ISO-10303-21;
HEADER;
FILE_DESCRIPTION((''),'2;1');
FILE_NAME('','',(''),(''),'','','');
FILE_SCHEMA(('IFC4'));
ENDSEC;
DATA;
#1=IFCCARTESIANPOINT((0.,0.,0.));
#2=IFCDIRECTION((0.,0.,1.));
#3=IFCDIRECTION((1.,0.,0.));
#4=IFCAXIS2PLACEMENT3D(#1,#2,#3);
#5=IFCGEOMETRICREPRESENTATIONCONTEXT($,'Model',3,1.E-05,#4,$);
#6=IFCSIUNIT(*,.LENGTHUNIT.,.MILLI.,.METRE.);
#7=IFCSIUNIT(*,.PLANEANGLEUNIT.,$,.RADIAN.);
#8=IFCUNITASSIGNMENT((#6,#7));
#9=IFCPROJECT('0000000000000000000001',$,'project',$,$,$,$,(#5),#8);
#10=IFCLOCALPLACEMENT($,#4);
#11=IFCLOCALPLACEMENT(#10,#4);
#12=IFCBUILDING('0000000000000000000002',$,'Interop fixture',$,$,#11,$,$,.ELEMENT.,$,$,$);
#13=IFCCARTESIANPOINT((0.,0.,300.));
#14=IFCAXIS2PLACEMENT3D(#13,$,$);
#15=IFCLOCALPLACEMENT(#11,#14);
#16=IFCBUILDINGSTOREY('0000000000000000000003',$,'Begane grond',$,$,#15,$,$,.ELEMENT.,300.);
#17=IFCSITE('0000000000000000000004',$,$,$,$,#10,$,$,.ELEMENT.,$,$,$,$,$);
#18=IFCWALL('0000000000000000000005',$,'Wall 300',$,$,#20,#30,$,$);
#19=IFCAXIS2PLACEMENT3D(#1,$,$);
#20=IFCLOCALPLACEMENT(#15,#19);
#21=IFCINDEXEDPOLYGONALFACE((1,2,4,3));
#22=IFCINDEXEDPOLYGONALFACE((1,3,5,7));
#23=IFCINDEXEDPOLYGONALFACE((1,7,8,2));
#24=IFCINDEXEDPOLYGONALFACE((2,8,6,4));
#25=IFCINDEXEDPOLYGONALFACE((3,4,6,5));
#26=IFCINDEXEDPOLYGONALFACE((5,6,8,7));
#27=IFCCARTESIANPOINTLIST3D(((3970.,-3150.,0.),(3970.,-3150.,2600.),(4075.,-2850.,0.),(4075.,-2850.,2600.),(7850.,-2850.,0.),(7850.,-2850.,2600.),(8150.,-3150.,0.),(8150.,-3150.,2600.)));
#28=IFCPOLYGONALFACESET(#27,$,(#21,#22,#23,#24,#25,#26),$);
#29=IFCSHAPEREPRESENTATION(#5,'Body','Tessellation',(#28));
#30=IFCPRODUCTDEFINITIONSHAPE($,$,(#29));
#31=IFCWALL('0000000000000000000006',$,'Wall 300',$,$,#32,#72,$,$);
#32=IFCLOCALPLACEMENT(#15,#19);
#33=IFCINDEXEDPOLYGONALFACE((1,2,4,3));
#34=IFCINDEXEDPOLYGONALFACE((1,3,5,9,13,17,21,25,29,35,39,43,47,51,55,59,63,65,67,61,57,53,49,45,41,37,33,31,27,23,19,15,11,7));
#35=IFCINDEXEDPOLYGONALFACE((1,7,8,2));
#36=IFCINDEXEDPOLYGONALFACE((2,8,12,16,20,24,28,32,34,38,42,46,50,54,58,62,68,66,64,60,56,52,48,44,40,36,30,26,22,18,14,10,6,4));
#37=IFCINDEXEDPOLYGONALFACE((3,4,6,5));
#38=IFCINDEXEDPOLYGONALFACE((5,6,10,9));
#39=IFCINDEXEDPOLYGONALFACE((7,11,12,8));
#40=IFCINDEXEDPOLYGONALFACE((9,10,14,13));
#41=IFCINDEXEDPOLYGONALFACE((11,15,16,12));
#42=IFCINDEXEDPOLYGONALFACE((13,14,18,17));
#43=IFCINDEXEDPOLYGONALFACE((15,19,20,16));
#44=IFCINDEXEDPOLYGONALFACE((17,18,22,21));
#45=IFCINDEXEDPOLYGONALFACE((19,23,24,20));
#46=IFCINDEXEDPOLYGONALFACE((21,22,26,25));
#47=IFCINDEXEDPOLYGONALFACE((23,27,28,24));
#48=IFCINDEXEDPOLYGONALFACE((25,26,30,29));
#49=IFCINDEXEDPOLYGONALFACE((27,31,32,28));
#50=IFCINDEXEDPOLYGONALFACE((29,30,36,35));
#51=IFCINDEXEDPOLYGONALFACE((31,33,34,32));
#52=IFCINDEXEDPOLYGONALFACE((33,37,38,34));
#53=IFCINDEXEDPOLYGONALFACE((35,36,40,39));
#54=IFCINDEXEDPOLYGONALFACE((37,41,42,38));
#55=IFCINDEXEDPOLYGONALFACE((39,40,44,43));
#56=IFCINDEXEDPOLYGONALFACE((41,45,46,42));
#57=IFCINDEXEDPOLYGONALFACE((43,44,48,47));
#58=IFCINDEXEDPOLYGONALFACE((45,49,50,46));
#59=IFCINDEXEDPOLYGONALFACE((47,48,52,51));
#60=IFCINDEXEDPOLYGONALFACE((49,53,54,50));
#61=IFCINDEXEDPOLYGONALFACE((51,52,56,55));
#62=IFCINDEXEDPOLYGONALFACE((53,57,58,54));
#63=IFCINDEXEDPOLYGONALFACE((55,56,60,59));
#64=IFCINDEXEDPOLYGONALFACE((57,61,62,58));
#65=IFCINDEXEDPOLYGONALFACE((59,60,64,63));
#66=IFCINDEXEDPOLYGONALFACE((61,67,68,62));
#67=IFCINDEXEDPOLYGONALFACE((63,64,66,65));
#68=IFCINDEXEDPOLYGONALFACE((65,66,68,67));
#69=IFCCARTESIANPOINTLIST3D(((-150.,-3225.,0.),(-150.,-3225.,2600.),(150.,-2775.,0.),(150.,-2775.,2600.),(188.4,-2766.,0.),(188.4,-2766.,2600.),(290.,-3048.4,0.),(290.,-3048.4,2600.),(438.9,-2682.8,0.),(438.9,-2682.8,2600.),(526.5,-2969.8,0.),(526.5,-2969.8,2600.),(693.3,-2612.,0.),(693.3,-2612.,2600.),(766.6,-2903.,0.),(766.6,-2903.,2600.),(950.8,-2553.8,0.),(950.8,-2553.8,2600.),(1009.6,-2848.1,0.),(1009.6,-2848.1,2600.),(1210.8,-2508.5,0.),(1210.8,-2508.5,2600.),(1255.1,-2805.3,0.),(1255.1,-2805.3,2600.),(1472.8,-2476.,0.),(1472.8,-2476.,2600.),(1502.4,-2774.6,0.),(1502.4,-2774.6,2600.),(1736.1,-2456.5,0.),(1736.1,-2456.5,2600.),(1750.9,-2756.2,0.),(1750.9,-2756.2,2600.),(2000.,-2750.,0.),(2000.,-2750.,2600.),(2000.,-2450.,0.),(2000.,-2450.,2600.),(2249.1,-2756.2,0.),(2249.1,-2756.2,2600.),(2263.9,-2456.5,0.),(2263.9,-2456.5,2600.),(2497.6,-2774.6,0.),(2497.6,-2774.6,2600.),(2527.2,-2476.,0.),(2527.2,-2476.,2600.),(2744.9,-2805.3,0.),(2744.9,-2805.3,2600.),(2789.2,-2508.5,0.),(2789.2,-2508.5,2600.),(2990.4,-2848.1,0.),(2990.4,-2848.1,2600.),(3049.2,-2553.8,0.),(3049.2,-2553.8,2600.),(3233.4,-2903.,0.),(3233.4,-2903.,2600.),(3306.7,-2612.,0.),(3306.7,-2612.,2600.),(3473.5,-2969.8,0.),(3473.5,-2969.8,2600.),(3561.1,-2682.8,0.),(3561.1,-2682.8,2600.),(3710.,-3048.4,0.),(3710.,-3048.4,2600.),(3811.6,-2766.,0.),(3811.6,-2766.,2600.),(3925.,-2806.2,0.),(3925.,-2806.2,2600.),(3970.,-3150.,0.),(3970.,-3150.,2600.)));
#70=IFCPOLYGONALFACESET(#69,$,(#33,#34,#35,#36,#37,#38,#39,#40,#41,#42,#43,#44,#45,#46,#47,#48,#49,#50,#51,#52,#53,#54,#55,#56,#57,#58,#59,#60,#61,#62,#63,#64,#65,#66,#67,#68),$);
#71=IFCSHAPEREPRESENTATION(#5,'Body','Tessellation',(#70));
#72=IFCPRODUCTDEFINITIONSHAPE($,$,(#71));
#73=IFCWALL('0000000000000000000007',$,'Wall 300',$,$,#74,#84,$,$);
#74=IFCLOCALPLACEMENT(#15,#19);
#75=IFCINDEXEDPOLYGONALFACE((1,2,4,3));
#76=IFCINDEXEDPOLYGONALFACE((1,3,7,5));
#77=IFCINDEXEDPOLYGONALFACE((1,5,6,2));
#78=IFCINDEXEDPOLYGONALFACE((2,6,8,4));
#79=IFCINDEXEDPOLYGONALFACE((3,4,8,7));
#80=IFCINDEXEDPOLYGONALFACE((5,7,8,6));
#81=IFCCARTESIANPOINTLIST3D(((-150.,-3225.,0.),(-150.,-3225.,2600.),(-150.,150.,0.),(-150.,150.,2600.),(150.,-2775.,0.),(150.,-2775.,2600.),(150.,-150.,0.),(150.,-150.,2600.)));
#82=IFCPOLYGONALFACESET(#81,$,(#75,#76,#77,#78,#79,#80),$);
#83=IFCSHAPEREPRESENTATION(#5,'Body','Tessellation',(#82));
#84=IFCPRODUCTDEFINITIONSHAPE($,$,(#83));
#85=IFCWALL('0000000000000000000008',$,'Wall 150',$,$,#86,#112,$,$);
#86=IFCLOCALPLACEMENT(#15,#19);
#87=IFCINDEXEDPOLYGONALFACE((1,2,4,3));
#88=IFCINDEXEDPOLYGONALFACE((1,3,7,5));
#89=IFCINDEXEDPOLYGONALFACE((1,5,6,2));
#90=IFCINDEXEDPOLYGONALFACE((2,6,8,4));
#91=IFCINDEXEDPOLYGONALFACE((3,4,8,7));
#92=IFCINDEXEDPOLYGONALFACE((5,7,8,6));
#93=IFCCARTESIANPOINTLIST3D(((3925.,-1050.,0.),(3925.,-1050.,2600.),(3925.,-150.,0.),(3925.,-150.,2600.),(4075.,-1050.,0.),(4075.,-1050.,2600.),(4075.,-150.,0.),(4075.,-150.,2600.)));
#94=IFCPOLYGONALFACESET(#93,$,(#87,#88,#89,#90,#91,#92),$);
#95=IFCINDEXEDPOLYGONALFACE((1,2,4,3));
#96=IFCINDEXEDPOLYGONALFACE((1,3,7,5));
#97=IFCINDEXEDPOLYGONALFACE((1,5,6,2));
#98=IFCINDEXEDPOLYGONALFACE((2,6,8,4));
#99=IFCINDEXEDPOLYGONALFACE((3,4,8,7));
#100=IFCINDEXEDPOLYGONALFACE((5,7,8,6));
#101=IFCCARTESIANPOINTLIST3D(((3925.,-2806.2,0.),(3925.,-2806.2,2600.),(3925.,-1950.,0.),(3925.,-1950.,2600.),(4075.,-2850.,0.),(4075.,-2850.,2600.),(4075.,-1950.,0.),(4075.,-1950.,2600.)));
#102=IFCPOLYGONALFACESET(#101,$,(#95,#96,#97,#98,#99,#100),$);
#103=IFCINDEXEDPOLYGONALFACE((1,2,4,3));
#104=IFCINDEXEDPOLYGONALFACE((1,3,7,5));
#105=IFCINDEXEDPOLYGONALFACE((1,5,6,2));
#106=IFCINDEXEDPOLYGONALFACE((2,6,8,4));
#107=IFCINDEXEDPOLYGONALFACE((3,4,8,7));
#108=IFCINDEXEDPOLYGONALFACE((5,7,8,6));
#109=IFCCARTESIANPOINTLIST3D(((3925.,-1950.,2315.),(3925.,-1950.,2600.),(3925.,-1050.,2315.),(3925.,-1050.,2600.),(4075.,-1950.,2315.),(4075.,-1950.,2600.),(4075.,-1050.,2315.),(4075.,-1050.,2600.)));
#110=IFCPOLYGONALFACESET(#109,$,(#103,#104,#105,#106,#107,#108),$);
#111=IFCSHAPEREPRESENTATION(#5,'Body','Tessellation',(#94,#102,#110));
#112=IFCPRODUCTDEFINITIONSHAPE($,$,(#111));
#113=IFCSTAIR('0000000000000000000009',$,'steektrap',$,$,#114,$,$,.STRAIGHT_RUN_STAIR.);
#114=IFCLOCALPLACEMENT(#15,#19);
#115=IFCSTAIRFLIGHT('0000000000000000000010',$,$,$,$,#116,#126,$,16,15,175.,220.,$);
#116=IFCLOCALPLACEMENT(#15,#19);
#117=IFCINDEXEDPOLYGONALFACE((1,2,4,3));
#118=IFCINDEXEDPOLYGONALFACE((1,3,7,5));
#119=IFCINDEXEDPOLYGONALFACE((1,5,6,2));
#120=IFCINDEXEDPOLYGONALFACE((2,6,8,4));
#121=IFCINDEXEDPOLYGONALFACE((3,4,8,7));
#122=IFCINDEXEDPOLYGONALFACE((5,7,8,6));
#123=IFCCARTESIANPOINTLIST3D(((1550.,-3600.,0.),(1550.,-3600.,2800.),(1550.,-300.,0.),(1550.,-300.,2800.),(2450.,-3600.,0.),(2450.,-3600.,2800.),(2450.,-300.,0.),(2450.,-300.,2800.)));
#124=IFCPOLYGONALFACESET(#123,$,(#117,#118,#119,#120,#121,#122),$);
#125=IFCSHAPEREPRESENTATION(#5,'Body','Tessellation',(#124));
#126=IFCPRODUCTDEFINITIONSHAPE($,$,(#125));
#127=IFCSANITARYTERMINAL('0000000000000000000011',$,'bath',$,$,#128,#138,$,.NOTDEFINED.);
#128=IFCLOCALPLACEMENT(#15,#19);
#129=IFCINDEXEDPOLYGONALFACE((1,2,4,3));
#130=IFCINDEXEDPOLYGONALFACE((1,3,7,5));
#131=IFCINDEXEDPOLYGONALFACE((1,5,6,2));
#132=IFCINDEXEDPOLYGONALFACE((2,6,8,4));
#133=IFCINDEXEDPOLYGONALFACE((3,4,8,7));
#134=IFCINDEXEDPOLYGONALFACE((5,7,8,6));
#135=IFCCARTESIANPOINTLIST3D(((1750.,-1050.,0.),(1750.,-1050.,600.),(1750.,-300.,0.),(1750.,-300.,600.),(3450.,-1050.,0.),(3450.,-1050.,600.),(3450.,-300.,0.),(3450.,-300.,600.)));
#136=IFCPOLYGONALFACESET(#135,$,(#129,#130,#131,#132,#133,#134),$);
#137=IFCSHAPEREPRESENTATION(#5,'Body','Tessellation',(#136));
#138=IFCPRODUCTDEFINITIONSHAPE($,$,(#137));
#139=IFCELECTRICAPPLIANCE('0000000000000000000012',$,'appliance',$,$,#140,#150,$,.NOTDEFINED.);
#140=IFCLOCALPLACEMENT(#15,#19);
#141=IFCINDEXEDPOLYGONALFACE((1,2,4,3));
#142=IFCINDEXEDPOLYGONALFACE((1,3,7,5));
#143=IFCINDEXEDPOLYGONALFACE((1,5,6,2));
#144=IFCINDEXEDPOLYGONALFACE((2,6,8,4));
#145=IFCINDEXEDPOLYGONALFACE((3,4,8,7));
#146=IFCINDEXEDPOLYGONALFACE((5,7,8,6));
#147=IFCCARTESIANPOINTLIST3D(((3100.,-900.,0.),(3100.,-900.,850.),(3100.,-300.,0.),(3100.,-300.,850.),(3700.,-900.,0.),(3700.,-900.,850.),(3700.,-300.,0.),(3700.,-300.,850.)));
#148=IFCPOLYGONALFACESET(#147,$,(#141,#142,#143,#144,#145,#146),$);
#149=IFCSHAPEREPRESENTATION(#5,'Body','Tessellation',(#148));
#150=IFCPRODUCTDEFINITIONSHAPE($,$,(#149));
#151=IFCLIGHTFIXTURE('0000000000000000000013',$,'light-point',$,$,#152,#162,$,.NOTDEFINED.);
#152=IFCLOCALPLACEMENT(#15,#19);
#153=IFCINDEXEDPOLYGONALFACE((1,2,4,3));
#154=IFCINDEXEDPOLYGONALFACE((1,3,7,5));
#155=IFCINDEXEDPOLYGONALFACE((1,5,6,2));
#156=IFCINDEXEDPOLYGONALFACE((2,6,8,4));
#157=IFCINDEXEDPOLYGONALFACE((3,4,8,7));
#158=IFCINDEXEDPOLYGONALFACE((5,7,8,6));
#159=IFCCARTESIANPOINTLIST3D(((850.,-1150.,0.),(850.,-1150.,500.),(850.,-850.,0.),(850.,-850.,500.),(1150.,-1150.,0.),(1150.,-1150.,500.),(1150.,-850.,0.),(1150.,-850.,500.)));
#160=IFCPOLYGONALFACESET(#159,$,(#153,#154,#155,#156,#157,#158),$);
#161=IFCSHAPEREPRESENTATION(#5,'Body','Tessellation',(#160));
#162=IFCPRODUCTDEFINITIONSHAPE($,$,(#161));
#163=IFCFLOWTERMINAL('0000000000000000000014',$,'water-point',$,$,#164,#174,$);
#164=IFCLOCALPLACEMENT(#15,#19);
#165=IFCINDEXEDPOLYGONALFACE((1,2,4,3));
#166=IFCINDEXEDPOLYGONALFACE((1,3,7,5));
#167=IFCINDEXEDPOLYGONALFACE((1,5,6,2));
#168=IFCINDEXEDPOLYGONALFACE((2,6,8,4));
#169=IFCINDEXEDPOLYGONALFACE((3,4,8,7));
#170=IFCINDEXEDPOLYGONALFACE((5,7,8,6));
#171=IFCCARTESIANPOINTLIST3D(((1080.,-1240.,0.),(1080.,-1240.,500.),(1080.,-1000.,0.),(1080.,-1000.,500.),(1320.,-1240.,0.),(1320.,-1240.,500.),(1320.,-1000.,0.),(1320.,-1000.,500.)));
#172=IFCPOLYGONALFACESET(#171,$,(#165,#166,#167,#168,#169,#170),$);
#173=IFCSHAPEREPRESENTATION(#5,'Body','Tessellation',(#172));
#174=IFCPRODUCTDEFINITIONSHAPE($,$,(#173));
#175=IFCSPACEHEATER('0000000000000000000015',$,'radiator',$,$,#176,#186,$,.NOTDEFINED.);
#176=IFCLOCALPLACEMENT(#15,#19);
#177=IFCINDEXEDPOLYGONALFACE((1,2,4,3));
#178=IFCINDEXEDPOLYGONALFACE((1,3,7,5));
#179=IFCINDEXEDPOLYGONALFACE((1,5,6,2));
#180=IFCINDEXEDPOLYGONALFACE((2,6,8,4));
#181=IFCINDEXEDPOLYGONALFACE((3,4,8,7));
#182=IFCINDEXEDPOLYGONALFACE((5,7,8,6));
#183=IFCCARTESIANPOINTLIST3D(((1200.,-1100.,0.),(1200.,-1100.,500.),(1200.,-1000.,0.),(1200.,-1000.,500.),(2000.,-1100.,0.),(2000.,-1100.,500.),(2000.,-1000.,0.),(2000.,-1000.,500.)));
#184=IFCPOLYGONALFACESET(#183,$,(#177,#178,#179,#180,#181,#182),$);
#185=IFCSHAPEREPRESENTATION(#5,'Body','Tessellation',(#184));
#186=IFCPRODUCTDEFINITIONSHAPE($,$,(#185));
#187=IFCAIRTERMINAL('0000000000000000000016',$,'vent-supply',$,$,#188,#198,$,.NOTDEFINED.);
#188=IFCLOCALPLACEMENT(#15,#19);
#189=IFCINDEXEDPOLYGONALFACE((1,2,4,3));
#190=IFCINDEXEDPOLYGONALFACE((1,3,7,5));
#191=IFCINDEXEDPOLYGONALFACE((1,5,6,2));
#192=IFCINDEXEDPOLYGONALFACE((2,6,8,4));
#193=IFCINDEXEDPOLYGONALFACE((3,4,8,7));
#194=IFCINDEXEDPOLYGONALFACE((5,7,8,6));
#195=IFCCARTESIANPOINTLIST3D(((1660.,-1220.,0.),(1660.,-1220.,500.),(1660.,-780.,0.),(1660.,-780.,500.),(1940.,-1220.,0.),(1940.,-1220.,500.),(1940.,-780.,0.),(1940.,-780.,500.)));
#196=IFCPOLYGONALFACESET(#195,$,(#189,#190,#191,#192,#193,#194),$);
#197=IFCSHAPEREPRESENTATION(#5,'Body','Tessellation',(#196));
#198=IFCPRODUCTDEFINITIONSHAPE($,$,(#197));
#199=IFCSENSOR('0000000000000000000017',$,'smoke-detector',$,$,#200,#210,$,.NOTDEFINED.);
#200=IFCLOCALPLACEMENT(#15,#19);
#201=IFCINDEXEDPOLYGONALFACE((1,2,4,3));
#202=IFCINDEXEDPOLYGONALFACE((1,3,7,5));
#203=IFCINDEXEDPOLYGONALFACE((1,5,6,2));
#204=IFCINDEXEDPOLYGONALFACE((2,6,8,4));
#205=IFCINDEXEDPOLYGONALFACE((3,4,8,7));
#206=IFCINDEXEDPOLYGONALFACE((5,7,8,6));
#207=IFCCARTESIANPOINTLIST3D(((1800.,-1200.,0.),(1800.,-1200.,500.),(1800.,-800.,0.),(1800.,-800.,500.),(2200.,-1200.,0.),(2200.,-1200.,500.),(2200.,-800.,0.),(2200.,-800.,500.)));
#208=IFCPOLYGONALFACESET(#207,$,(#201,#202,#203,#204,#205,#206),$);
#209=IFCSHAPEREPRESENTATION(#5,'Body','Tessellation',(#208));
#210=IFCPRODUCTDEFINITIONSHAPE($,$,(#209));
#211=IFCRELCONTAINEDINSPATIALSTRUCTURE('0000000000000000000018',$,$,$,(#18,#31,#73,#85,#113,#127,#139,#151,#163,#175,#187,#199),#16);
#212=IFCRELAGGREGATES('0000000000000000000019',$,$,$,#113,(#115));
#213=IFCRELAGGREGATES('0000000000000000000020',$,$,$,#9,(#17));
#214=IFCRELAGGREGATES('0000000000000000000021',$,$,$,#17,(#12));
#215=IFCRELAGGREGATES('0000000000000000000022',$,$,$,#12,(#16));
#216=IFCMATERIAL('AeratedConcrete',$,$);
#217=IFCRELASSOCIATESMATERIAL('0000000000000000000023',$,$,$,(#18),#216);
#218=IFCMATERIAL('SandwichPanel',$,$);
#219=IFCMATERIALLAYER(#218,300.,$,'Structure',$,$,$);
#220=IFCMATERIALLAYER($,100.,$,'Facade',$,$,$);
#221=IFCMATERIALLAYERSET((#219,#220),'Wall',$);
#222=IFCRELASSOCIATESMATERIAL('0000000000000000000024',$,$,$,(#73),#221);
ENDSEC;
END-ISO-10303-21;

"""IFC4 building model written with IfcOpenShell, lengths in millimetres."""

from ifc_helpers import new_model, si_unit, frame, origin, origin_with_axes, place, context, project, spatial, polyline, outline, extrude, material, layer, layer_set, element, aggregate, save


model = new_model("IFC4")

# Units and contexts
model_context = context("Model", 3, precision=1e-05, world=origin_with_axes())
ifc_project = project(units=[si_unit("LENGTHUNIT", "METRE", prefix="MILLI"), si_unit("PLANEANGLEUNIT", "RADIAN")], contexts=[model_context])

# Site, building, storey
site_placement = place(None, origin_with_axes())
building_placement = place(site_placement, origin_with_axes())
storey_placement = place(building_placement, frame((0.0, 0.0, 300.0)))
placement = place(storey_placement, origin_with_axes())
site = spatial("IfcSite", under=ifc_project, at=site_placement, CompositionType="ELEMENT")
building = spatial("IfcBuilding", under=site, at=building_placement, Name="Interop fixture", CompositionType="ELEMENT")
storey = spatial("IfcBuildingStorey", under=building, at=storey_placement, Name="Begane grond", CompositionType="ELEMENT", Elevation=300.0)

# Walls
ifc_material_1 = material(Name="AeratedConcrete")
element("IfcWall", 1, at=placement, inside=storey, material=ifc_material_1, Name="Wall 300", context=model_context, shape_type="SweptSolid", body=[
    extrude(outline(polyline([(7850.0, -2850.0), (4075.0, -2850.0), (3970.0, -3150.0), (8150.0, -3150.0), (7850.0, -2850.0)])), origin(), (0.0, 0.0, 1.0), 2600.0),
])
element("IfcWall", 2, at=placement, inside=storey, Name="Wall 300", context=model_context, shape_type="SweptSolid", body=[
    extrude(outline(polyline([(3925.0, -2806.2), (3811.6, -2766.0), (3561.1, -2682.8), (3306.7, -2612.0), (3049.2, -2553.8), (2789.2, -2508.5), (2527.2, -2476.0), (2263.9, -2456.5), (2000.0, -2450.0), (1736.1, -2456.5), (1472.8, -2476.0), (1210.8, -2508.5), (950.8, -2553.8), (693.3, -2612.0), (438.9, -2682.8), (188.4, -2766.0), (150.0, -2775.0), (-150.0, -3225.0), (290.0, -3048.4), (526.5, -2969.8), (766.6, -2903.0), (1009.6, -2848.1), (1255.1, -2805.3), (1502.4, -2774.6), (1750.9, -2756.2), (2000.0, -2750.0), (2249.1, -2756.2), (2497.6, -2774.6), (2744.9, -2805.3), (2990.4, -2848.1), (3233.4, -2903.0), (3473.5, -2969.8), (3710.0, -3048.4), (3970.0, -3150.0), (3925.0, -2806.2)])), origin(), (0.0, 0.0, 1.0), 2600.0),
])
ifc_material_2 = material(Name="SandwichPanel")
ifc_layer_1 = layer(ifc_material_2, 300.0, Name="Structure")
ifc_layer_2 = layer(None, 100.0, Name="Facade")
ifc_layer_set = layer_set([ifc_layer_1, ifc_layer_2], Name="Wall")
element("IfcWall", 3, at=placement, inside=storey, material=ifc_layer_set, Name="Wall 300", context=model_context, shape_type="SweptSolid", body=[
    extrude(outline(polyline([(150.0, -2775.0), (150.0, -150.0), (-150.0, 150.0), (-150.0, -3225.0), (150.0, -2775.0)])), origin(), (0.0, 0.0, 1.0), 2600.0),
])

# Wall, opening
wall_1 = element("IfcWall", 4, at=placement, inside=storey, Name="Wall 150", context=model_context, shape_type="SweptSolid", body=[
    extrude(outline(polyline([(3925.0, -150.0), (3925.0, -1050.0), (4075.0, -1050.0), (4075.0, -150.0), (3925.0, -150.0)])), origin(), (0.0, 0.0, 1.0), 2600.0),
    extrude(outline(polyline([(3925.0, -1950.0), (3925.0, -2806.2), (4075.0, -2850.0), (4075.0, -1950.0), (3925.0, -1950.0)])), origin(), (0.0, 0.0, 1.0), 2600.0),
    extrude(outline(polyline([(3925.0, -1050.0), (3925.0, -1950.0), (4075.0, -1950.0), (4075.0, -1050.0), (3925.0, -1050.0)])), frame((0.0, 0.0, 2315.0)), (0.0, 0.0, 1.0), 285.0),
])
element("IfcOpeningElement", 5, at=placement, cuts=wall_1, context=model_context, shape_type="SweptSolid", body=[
    extrude(outline(polyline([(3925.0, -1050.0), (3925.0, -1950.0), (4075.0, -1950.0), (4075.0, -1050.0), (3925.0, -1050.0)])), origin(), (0.0, 0.0, 1.0), 2315.0),
])

# Stair, stair flight
stair = element("IfcStair", 6, at=placement, inside=storey, Name="steektrap", PredefinedType="STRAIGHT_RUN_STAIR")
stair_flight = element("IfcStairFlight", 7, at=placement, NumberOfRisers=16, NumberOfTreads=15, RiserHeight=175.0, TreadLength=220.0, context=model_context, shape_type="SweptSolid", body=[
    extrude(outline(polyline([(1550.0, -300.0), (2450.0, -300.0), (2450.0, -3600.0), (1550.0, -3600.0), (1550.0, -300.0)])), origin(), (0.0, 0.0, 1.0), 2800.0),
])
aggregate(stair, [stair_flight])

# Sanitary terminal
element("IfcSanitaryTerminal", 8, at=placement, inside=storey, Name="bath", PredefinedType="NOTDEFINED", context=model_context, shape_type="SweptSolid", body=[
    extrude(outline(polyline([(1750.0, -300.0), (3450.0, -300.0), (3450.0, -1050.0), (1750.0, -1050.0), (1750.0, -300.0)])), origin(), (0.0, 0.0, 1.0), 600.0),
])

# Electric appliance
element("IfcElectricAppliance", 9, at=placement, inside=storey, Name="appliance", PredefinedType="NOTDEFINED", context=model_context, shape_type="SweptSolid", body=[
    extrude(outline(polyline([(3100.0, -300.0), (3700.0, -300.0), (3700.0, -900.0), (3100.0, -900.0), (3100.0, -300.0)])), origin(), (0.0, 0.0, 1.0), 850.0),
])

# Light fixture
element("IfcLightFixture", 10, at=placement, inside=storey, Name="light-point", PredefinedType="NOTDEFINED", context=model_context, shape_type="SweptSolid", body=[
    extrude(outline(polyline([(850.0, -850.0), (1150.0, -850.0), (1150.0, -1150.0), (850.0, -1150.0), (850.0, -850.0)])), origin(), (0.0, 0.0, 1.0), 500.0),
])

# Flow terminal
element("IfcFlowTerminal", 11, at=placement, inside=storey, Name="water-point", context=model_context, shape_type="SweptSolid", body=[
    extrude(outline(polyline([(1080.0, -1000.0), (1320.0, -1000.0), (1320.0, -1240.0), (1080.0, -1240.0), (1080.0, -1000.0)])), origin(), (0.0, 0.0, 1.0), 500.0),
])

# Space heater
element("IfcSpaceHeater", 12, at=placement, inside=storey, Name="radiator", PredefinedType="NOTDEFINED", context=model_context, shape_type="SweptSolid", body=[
    extrude(outline(polyline([(1200.0, -1000.0), (2000.0, -1000.0), (2000.0, -1100.0), (1200.0, -1100.0), (1200.0, -1000.0)])), origin(), (0.0, 0.0, 1.0), 500.0),
])

# Air terminal
element("IfcAirTerminal", 13, at=placement, inside=storey, Name="vent-supply", PredefinedType="NOTDEFINED", context=model_context, shape_type="SweptSolid", body=[
    extrude(outline(polyline([(1660.0, -780.0), (1940.0, -780.0), (1940.0, -1220.0), (1660.0, -1220.0), (1660.0, -780.0)])), origin(), (0.0, 0.0, 1.0), 500.0),
])

# Sensor
element("IfcSensor", 14, at=placement, inside=storey, Name="smoke-detector", PredefinedType="NOTDEFINED", context=model_context, shape_type="SweptSolid", body=[
    extrude(outline(polyline([(1800.0, -800.0), (2200.0, -800.0), (2200.0, -1200.0), (1800.0, -1200.0), (1800.0, -800.0)])), origin(), (0.0, 0.0, 1.0), 500.0),
])

save(model, "model.ifc")
